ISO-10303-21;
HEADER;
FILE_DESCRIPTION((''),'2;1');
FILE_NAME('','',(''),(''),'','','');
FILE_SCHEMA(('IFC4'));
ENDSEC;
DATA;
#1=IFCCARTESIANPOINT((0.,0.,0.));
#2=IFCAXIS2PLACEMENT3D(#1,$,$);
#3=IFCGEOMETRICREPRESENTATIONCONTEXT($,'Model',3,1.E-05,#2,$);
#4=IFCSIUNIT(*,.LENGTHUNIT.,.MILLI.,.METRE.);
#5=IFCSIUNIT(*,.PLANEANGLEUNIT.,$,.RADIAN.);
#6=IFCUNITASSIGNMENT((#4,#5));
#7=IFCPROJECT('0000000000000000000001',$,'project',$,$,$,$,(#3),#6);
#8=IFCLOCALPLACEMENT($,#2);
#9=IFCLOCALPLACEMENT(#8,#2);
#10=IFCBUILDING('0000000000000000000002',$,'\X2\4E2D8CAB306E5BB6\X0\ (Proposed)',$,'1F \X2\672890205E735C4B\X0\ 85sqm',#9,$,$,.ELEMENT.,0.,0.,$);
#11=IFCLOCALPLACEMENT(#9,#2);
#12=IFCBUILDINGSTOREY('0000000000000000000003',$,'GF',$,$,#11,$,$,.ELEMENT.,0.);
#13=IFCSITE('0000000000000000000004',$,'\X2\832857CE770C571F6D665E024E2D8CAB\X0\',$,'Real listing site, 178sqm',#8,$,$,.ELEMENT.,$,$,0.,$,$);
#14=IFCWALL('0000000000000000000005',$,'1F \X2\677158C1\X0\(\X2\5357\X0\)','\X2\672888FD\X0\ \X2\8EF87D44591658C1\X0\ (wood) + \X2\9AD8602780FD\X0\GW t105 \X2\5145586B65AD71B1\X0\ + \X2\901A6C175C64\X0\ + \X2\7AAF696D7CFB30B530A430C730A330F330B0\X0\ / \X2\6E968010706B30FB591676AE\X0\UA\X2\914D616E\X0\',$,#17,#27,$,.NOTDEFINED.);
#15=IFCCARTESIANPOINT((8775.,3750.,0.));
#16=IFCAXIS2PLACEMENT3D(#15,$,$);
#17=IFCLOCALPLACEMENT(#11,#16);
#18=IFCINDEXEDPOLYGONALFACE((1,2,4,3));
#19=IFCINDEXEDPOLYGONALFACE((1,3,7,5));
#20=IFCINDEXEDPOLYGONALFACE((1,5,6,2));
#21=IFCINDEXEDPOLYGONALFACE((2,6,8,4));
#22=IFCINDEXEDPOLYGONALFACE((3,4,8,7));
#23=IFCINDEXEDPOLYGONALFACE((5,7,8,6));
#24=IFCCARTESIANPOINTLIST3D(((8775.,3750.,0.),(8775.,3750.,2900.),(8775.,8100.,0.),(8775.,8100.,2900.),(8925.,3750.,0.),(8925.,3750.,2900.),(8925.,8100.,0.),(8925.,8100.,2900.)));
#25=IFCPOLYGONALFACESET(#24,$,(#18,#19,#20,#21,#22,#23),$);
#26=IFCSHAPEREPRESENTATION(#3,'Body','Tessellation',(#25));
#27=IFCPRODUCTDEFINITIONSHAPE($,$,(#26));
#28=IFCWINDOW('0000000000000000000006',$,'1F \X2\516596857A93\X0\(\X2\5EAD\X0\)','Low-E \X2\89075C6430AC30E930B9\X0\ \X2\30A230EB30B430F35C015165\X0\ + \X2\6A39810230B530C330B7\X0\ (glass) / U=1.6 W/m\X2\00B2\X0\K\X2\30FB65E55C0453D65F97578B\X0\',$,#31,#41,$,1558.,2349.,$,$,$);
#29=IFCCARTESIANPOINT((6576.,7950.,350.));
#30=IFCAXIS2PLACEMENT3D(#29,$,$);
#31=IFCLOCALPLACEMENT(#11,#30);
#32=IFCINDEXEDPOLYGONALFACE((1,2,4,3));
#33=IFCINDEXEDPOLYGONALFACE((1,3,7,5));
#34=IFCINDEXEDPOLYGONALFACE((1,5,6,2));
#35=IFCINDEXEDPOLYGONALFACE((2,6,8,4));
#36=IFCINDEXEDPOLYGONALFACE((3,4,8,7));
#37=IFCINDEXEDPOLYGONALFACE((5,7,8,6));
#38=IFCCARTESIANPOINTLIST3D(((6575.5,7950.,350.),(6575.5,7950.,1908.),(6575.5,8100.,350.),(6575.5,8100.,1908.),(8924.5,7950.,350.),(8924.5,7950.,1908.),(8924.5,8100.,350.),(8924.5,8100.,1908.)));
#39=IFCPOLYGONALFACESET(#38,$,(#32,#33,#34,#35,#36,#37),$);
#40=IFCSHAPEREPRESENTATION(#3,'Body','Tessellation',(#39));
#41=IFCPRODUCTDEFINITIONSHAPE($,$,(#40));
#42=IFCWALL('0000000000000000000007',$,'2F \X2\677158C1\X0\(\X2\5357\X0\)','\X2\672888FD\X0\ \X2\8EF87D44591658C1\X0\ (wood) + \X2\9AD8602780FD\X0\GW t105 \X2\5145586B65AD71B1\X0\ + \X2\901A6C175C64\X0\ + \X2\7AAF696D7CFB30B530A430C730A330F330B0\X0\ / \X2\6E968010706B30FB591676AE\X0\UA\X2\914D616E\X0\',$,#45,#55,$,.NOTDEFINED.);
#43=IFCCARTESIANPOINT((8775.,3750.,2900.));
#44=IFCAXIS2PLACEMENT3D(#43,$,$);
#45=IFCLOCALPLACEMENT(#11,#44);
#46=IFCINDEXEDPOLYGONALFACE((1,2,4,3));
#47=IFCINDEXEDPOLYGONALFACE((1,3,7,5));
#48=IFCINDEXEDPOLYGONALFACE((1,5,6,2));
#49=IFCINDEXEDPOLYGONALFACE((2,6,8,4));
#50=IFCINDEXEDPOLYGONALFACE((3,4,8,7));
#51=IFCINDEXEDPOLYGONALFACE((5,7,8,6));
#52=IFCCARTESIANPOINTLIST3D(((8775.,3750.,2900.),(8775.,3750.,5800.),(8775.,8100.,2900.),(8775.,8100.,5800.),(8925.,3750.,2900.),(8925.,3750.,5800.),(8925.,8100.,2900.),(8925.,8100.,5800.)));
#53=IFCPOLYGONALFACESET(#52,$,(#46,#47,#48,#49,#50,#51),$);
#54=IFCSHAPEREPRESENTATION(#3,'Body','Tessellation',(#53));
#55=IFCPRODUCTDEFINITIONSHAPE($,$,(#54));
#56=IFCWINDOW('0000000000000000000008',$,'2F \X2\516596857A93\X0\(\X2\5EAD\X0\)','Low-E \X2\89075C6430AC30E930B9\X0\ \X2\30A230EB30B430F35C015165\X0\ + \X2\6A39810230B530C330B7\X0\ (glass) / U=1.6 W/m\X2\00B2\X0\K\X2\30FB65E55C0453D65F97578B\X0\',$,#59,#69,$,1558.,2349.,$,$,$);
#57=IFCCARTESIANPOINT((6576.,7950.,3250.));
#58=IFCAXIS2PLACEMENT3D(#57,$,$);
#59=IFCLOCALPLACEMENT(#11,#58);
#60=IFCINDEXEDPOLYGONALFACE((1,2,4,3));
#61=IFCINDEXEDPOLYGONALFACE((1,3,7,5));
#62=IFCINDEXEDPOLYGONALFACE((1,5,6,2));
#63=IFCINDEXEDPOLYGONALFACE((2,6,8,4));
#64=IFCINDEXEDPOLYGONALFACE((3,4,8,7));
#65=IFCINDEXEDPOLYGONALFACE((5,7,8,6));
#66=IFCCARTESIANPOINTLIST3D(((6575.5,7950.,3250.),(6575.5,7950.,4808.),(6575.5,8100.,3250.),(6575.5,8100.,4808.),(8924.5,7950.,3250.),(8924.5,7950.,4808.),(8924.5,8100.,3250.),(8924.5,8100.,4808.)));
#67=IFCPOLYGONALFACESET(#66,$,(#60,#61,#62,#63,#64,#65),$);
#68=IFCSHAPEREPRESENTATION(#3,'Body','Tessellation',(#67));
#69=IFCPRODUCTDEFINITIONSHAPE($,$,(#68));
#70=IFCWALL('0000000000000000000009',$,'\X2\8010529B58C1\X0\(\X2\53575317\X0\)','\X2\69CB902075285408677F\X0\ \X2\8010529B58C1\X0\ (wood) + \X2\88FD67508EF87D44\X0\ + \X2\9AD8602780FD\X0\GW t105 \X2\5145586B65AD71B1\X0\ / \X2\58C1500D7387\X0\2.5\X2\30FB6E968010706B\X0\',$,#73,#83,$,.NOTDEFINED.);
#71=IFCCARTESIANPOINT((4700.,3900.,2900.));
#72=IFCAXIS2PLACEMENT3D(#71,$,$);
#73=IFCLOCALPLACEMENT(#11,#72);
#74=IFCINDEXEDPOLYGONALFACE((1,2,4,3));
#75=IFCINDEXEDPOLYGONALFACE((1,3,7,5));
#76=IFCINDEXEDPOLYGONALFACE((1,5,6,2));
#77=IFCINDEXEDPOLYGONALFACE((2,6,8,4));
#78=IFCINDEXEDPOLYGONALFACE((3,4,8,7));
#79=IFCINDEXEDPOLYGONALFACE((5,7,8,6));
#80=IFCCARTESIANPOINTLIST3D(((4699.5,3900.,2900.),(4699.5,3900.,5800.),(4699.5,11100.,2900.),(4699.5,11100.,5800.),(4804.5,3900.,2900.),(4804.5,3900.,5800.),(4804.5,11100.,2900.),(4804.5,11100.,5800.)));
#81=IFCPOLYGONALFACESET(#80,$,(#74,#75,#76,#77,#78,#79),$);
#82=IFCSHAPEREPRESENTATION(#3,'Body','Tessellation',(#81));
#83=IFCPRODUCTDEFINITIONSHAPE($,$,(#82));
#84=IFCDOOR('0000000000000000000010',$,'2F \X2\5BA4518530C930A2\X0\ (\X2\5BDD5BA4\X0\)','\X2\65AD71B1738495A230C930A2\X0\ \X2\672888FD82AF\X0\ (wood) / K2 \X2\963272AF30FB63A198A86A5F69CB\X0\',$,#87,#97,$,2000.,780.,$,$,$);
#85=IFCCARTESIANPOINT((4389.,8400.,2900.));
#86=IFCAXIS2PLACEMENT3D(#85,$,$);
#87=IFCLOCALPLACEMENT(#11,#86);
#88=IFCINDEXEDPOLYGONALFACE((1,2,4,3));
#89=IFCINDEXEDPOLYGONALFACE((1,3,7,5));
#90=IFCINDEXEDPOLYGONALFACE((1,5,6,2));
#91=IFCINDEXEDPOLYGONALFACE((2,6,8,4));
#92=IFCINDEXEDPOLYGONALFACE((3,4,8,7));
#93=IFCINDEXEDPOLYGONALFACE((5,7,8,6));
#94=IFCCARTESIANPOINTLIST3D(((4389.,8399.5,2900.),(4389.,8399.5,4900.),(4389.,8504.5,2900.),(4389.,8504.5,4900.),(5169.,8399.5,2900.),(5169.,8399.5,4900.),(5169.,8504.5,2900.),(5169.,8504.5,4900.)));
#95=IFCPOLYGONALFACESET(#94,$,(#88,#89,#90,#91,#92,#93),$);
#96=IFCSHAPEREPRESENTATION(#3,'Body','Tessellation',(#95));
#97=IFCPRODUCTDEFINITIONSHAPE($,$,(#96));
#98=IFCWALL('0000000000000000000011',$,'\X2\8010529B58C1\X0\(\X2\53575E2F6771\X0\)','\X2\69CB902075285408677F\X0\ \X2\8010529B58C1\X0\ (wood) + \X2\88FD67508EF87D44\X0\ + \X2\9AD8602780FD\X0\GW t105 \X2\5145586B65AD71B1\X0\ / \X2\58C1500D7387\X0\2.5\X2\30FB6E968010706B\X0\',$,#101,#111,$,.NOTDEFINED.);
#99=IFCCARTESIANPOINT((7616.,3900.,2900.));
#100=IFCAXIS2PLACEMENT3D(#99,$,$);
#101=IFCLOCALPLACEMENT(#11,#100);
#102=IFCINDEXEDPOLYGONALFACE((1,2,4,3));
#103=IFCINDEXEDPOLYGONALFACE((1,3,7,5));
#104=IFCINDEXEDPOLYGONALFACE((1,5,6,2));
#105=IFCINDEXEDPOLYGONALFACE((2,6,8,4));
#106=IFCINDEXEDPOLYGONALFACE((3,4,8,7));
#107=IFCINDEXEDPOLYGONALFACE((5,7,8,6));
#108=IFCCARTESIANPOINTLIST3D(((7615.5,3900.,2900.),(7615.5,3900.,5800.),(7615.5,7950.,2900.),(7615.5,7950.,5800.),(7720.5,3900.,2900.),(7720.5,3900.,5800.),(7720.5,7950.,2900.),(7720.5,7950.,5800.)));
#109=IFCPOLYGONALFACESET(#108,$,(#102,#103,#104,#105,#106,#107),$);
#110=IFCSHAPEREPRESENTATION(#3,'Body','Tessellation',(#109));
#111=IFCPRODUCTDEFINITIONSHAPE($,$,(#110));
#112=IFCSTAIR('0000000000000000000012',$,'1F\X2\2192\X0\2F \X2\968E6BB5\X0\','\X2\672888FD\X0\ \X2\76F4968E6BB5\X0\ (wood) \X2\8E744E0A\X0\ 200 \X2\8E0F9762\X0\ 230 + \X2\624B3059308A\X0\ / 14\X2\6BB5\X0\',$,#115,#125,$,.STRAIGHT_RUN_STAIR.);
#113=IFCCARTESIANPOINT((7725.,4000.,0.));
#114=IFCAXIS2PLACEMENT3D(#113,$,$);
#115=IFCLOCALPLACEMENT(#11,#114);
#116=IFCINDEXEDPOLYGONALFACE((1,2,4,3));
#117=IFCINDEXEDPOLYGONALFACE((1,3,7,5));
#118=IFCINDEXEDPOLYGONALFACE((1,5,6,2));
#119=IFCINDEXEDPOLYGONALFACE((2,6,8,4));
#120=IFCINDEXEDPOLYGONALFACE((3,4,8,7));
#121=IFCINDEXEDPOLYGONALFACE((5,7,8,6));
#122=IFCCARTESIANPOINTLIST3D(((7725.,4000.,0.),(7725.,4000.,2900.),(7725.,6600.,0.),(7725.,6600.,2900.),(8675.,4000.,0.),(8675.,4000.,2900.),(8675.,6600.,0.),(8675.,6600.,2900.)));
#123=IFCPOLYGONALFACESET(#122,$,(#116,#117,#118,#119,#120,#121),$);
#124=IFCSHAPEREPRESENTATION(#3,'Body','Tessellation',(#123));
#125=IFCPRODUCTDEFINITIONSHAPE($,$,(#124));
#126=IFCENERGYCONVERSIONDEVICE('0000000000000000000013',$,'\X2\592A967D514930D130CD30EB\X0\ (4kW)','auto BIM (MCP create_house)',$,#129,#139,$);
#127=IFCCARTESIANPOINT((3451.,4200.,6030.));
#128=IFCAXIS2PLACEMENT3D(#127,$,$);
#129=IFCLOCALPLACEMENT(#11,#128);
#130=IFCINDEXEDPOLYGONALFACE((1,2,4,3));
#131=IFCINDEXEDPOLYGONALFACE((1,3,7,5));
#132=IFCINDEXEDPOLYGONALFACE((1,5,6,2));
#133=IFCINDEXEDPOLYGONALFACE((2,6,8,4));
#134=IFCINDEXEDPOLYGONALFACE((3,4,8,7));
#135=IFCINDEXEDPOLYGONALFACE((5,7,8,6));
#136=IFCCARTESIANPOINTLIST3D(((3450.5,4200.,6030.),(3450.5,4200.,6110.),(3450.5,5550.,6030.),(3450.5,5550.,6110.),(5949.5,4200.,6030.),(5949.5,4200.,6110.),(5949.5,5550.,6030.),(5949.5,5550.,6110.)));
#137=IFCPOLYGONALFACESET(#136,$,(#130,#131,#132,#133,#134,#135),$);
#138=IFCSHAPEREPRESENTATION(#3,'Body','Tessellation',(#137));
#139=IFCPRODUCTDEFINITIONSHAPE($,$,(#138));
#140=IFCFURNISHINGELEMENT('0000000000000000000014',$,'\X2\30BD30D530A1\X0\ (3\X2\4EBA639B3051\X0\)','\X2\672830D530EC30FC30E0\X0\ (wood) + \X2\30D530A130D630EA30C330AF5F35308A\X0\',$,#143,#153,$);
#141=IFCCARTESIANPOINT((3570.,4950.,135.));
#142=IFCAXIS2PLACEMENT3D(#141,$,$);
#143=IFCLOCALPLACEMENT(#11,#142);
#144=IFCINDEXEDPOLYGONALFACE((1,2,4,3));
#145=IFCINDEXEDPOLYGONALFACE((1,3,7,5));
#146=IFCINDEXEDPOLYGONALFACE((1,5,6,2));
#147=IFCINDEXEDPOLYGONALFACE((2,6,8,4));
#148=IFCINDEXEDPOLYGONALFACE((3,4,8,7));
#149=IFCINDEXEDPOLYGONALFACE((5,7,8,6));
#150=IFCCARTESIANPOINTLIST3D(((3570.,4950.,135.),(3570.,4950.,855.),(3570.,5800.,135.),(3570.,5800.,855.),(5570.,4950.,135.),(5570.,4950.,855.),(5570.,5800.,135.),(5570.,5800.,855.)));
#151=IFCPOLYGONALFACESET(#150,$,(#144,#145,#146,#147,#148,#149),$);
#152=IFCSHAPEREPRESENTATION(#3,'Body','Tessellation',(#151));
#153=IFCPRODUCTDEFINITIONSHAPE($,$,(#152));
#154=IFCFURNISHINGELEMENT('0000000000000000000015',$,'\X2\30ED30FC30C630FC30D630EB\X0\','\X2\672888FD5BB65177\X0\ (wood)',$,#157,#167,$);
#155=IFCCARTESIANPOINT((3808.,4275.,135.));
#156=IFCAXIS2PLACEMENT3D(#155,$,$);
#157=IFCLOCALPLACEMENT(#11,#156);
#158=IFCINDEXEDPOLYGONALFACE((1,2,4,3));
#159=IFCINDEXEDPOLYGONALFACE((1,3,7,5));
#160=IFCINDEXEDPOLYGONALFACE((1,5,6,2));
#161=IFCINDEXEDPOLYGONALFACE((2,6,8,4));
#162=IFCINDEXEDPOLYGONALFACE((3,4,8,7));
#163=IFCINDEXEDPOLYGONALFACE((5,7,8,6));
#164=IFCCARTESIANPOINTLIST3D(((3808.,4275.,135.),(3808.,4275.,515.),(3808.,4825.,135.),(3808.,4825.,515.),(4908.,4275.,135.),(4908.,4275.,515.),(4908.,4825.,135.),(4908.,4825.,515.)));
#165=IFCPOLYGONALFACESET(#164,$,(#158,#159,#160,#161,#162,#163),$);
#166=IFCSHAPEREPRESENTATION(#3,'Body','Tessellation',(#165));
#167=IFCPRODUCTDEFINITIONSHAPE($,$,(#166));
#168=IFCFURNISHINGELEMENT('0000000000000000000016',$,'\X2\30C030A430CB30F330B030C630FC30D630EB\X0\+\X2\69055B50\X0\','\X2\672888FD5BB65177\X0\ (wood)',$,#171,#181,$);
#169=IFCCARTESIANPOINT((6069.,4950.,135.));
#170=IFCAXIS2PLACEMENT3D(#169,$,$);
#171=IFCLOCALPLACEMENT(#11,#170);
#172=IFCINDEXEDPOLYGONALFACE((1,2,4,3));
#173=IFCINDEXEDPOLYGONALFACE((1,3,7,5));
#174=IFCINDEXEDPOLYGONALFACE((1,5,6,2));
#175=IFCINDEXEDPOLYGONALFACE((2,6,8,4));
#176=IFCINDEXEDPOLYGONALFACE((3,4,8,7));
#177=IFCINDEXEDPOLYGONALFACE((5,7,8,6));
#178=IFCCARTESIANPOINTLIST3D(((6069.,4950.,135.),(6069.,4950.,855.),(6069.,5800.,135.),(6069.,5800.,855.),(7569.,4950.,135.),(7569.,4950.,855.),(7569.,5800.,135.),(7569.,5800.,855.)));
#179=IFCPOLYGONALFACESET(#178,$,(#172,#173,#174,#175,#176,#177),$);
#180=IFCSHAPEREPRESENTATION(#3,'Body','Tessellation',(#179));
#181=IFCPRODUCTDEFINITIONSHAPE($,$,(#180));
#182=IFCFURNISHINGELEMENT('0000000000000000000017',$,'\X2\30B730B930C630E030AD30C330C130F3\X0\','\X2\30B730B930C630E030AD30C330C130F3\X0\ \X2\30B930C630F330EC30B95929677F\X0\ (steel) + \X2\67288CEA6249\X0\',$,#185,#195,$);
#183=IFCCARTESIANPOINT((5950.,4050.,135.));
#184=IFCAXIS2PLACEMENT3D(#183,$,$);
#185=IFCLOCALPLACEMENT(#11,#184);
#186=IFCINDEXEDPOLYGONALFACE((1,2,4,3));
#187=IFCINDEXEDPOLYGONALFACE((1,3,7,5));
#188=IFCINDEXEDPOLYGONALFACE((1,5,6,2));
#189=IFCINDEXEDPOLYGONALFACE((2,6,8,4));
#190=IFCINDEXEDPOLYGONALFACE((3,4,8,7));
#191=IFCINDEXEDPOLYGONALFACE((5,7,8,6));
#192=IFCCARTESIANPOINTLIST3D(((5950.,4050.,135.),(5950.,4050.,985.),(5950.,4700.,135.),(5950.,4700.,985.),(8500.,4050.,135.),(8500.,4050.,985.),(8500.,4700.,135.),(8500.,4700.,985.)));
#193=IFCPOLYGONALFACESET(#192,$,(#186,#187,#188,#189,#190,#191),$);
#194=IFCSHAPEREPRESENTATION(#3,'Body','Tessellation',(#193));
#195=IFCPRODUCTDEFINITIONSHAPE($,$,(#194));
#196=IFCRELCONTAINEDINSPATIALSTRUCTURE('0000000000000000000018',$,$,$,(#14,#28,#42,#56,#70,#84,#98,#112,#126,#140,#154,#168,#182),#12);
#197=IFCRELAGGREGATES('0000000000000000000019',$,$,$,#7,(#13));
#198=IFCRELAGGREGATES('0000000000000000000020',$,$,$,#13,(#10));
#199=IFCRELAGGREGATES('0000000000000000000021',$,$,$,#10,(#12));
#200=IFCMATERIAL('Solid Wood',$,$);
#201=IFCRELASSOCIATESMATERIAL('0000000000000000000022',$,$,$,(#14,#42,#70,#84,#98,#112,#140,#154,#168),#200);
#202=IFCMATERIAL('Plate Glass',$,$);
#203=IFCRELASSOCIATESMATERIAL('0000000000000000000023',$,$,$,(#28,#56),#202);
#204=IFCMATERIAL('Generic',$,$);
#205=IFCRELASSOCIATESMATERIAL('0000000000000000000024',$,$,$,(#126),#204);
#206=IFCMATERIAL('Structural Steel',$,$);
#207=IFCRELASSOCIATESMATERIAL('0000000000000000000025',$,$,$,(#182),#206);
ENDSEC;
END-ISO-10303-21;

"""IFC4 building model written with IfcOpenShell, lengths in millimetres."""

from ifc_helpers import new_model, si_unit, frame, frame_2d, origin, place, context, project, spatial, rectangle, extrude, material, element, fill, save


model = new_model("IFC4")

# Units and contexts
model_context = context("Model", 3, precision=1e-05, world=origin())
ifc_project = project(units=[si_unit("LENGTHUNIT", "METRE", prefix="MILLI"), si_unit("PLANEANGLEUNIT", "RADIAN")], contexts=[model_context])

# Site, building, storey
site_placement = place(None, origin())
site = spatial("IfcSite", under=ifc_project, at=site_placement, Name="茨城県土浦市中貫", ObjectType="Real listing site, 178sqm", CompositionType="ELEMENT", RefElevation=0.0)
building_placement = place(site_placement, origin())
building = spatial("IfcBuilding", under=site, at=building_placement, Name="中貫の家 (Proposed)", ObjectType="1F 木造平屋 85sqm", CompositionType="ELEMENT", ElevationOfRefHeight=0.0, ElevationOfTerrain=0.0)
storey_placement = place(building_placement, origin())
storey = spatial("IfcBuildingStorey", under=building, at=storey_placement, Name="GF", CompositionType="ELEMENT", Elevation=0.0)

# Wall, opening, window
ifc_material_1 = material(Name="Solid Wood")
wall_1_placement = place(storey_placement, frame((8775.0, 3750.0, 0.0)))
wall_1 = element("IfcWall", 1, at=wall_1_placement, inside=storey, material=ifc_material_1, Name="1F 東壁(南)", Description="木製 軸組外壁 (wood) + 高性能GW t105 充填断熱 + 通気層 + 窯業系サイディング / 準耐火・外皮UA配慮", PredefinedType="NOTDEFINED", context=model_context, shape_type="SweptSolid", body=[
    extrude(rectangle(XDim=150.0, YDim=4350.0, at=frame_2d((75.0, 2175.0))), frame((8775.0, 3750.0, 0.0)), (0.0, 0.0, 1.0), 2900.0),
])
opening_1_placement = place(storey_placement, frame((6576.0, 7950.0, 350.0)))
opening_1 = element("IfcOpeningElement", 2, at=opening_1_placement, cuts=wall_1, PredefinedType="NOTDEFINED", context=model_context, shape_type="SweptSolid", body=[
    extrude(rectangle(XDim=2349.0, YDim=150.0, at=frame_2d((1174.0, 75.0))), frame((6576.0, 7950.0, 350.0)), (0.0, 0.0, 1.0), 1558.0),
])
ifc_material_2 = material(Name="Plate Glass")
window_1_placement = place(storey_placement, frame((6576.0, 7950.0, 350.0)))
window_1 = element("IfcWindow", 3, at=window_1_placement, inside=storey, material=ifc_material_2, Name="1F 入隅窓(庭)", Description="Low-E 複層ガラス アルゴン封入 + 樹脂サッシ (glass) / U=1.6 W/m²K・日射取得型", OverallHeight=1558.0, OverallWidth=2349.0, context=model_context, shape_type="SweptSolid", body=[
    extrude(rectangle(XDim=2349.0, YDim=150.0, at=frame_2d((1174.0, 75.0))), frame((6576.0, 7950.0, 350.0)), (0.0, 0.0, 1.0), 1558.0),
])
fill(opening_1, window_1)

# Wall, opening, window
wall_2_placement = place(storey_placement, frame((8775.0, 3750.0, 2900.0)))
wall_2 = element("IfcWall", 4, at=wall_2_placement, inside=storey, material=ifc_material_1, Name="2F 東壁(南)", Description="木製 軸組外壁 (wood) + 高性能GW t105 充填断熱 + 通気層 + 窯業系サイディング / 準耐火・外皮UA配慮", PredefinedType="NOTDEFINED", context=model_context, shape_type="SweptSolid", body=[
    extrude(rectangle(XDim=150.0, YDim=4350.0, at=frame_2d((75.0, 2175.0))), frame((8775.0, 3750.0, 2900.0)), (0.0, 0.0, 1.0), 2900.0),
])
opening_2_placement = place(storey_placement, frame((6576.0, 7950.0, 3250.0)))
opening_2 = element("IfcOpeningElement", 5, at=opening_2_placement, cuts=wall_2, PredefinedType="NOTDEFINED", context=model_context, shape_type="SweptSolid", body=[
    extrude(rectangle(XDim=2349.0, YDim=150.0, at=frame_2d((1174.0, 75.0))), frame((6576.0, 7950.0, 3250.0)), (0.0, 0.0, 1.0), 1558.0),
])
window_2_placement = place(storey_placement, frame((6576.0, 7950.0, 3250.0)))
window_2 = element("IfcWindow", 6, at=window_2_placement, inside=storey, material=ifc_material_2, Name="2F 入隅窓(庭)", Description="Low-E 複層ガラス アルゴン封入 + 樹脂サッシ (glass) / U=1.6 W/m²K・日射取得型", OverallHeight=1558.0, OverallWidth=2349.0, context=model_context, shape_type="SweptSolid", body=[
    extrude(rectangle(XDim=2349.0, YDim=150.0, at=frame_2d((1174.0, 75.0))), frame((6576.0, 7950.0, 3250.0)), (0.0, 0.0, 1.0), 1558.0),
])
fill(opening_2, window_2)

# Wall, opening, door
wall_3_placement = place(storey_placement, frame((4700.0, 3900.0, 2900.0)))
wall_3 = element("IfcWall", 7, at=wall_3_placement, inside=storey, material=ifc_material_1, Name="耐力壁(南北)", Description="構造用合板 耐力壁 (wood) + 製材軸組 + 高性能GW t105 充填断熱 / 壁倍率2.5・準耐火", PredefinedType="NOTDEFINED", context=model_context, shape_type="SweptSolid", body=[
    extrude(rectangle(XDim=105.0, YDim=7200.0, at=frame_2d((52.0, 3600.0))), frame((4700.0, 3900.0, 2900.0)), (0.0, 0.0, 1.0), 2900.0),
])
opening_3_placement = place(storey_placement, frame((4389.0, 8400.0, 2900.0)))
opening_3 = element("IfcOpeningElement", 8, at=opening_3_placement, cuts=wall_3, PredefinedType="NOTDEFINED", context=model_context, shape_type="SweptSolid", body=[
    extrude(rectangle(XDim=780.0, YDim=105.0, at=frame_2d((390.0, 52.0))), frame((4389.0, 8400.0, 2900.0)), (0.0, 0.0, 1.0), 2000.0),
])
door_1_placement = place(storey_placement, frame((4389.0, 8400.0, 2900.0)))
door_1 = element("IfcDoor", 9, at=door_1_placement, inside=storey, material=ifc_material_1, Name="2F 室内ドア (寝室)", Description="断熱玄関ドア 木製芯 (wood) / K2 防犯・採風機構", OverallHeight=2000.0, OverallWidth=780.0, context=model_context, shape_type="SweptSolid", body=[
    extrude(rectangle(XDim=780.0, YDim=105.0, at=frame_2d((390.0, 52.0))), frame((4389.0, 8400.0, 2900.0)), (0.0, 0.0, 1.0), 2000.0),
])
fill(opening_3, door_1)

# Wall
wall_4_placement = place(storey_placement, frame((7616.0, 3900.0, 2900.0)))
element("IfcWall", 10, at=wall_4_placement, inside=storey, material=ifc_material_1, Name="耐力壁(南帯東)", Description="構造用合板 耐力壁 (wood) + 製材軸組 + 高性能GW t105 充填断熱 / 壁倍率2.5・準耐火", PredefinedType="NOTDEFINED", context=model_context, shape_type="SweptSolid", body=[
    extrude(rectangle(XDim=105.0, YDim=4050.0, at=frame_2d((52.0, 2025.0))), frame((7616.0, 3900.0, 2900.0)), (0.0, 0.0, 1.0), 2900.0),
])

# Stair
stair_placement = place(storey_placement, frame((7725.0, 4000.0, 0.0)))
element("IfcStair", 11, at=stair_placement, inside=storey, material=ifc_material_1, Name="1F→2F 階段", Description="木製 直階段 (wood) 蹴上 200 踏面 230 + 手すり / 14段", PredefinedType="STRAIGHT_RUN_STAIR", context=model_context, shape_type="SweptSolid", body=[
    extrude(rectangle(XDim=950.0, YDim=2600.0, at=frame_2d((475.0, 1300.0))), frame((7725.0, 4000.0, 0.0)), (0.0, 0.0, 1.0), 2900.0),
])

# Energy conversion device
ifc_material_3 = material(Name="Generic")
energy_conversion_device_placement = place(storey_placement, frame((3451.0, 4200.0, 6030.0)))
element("IfcEnergyConversionDevice", 12, at=energy_conversion_device_placement, inside=storey, material=ifc_material_3, Name="太陽光パネル (4kW)", Description="auto BIM (MCP create_house)", context=model_context, shape_type="SweptSolid", body=[
    extrude(rectangle(XDim=2499.0, YDim=1350.0, at=frame_2d((1249.0, 675.0))), frame((3451.0, 4200.0, 6030.0)), (0.0, 0.0, 1.0), 80.0),
])

# Furnishing elements
furnishing_1_placement = place(storey_placement, frame((3570.0, 4950.0, 135.0)))
element("IfcFurnishingElement", 13, at=furnishing_1_placement, inside=storey, material=ifc_material_1, Name="ソファ (3人掛け)", Description="木フレーム (wood) + ファブリック張り", context=model_context, shape_type="SweptSolid", body=[
    extrude(rectangle(XDim=2000.0, YDim=850.0, at=frame_2d((1000.0, 425.0))), frame((3570.0, 4950.0, 135.0)), (0.0, 0.0, 1.0), 720.0),
])
furnishing_2_placement = place(storey_placement, frame((3808.0, 4275.0, 135.0)))
element("IfcFurnishingElement", 14, at=furnishing_2_placement, inside=storey, material=ifc_material_1, Name="ローテーブル", Description="木製家具 (wood)", context=model_context, shape_type="SweptSolid", body=[
    extrude(rectangle(XDim=1100.0, YDim=550.0, at=frame_2d((550.0, 275.0))), frame((3808.0, 4275.0, 135.0)), (0.0, 0.0, 1.0), 380.0),
])
furnishing_3_placement = place(storey_placement, frame((6069.0, 4950.0, 135.0)))
element("IfcFurnishingElement", 15, at=furnishing_3_placement, inside=storey, material=ifc_material_1, Name="ダイニングテーブル+椅子", Description="木製家具 (wood)", context=model_context, shape_type="SweptSolid", body=[
    extrude(rectangle(XDim=1500.0, YDim=850.0, at=frame_2d((750.0, 425.0))), frame((6069.0, 4950.0, 135.0)), (0.0, 0.0, 1.0), 720.0),
])
ifc_material_4 = material(Name="Structural Steel")
furnishing_4_placement = place(storey_placement, frame((5950.0, 4050.0, 135.0)))
element("IfcFurnishingElement", 16, at=furnishing_4_placement, inside=storey, material=ifc_material_4, Name="システムキッチン", Description="システムキッチン ステンレス天板 (steel) + 木質扉", context=model_context, shape_type="SweptSolid", body=[
    extrude(rectangle(XDim=2550.0, YDim=650.0, at=frame_2d((1275.0, 325.0))), frame((5950.0, 4050.0, 135.0)), (0.0, 0.0, 1.0), 850.0),
])

save(model, "model.ifc")
